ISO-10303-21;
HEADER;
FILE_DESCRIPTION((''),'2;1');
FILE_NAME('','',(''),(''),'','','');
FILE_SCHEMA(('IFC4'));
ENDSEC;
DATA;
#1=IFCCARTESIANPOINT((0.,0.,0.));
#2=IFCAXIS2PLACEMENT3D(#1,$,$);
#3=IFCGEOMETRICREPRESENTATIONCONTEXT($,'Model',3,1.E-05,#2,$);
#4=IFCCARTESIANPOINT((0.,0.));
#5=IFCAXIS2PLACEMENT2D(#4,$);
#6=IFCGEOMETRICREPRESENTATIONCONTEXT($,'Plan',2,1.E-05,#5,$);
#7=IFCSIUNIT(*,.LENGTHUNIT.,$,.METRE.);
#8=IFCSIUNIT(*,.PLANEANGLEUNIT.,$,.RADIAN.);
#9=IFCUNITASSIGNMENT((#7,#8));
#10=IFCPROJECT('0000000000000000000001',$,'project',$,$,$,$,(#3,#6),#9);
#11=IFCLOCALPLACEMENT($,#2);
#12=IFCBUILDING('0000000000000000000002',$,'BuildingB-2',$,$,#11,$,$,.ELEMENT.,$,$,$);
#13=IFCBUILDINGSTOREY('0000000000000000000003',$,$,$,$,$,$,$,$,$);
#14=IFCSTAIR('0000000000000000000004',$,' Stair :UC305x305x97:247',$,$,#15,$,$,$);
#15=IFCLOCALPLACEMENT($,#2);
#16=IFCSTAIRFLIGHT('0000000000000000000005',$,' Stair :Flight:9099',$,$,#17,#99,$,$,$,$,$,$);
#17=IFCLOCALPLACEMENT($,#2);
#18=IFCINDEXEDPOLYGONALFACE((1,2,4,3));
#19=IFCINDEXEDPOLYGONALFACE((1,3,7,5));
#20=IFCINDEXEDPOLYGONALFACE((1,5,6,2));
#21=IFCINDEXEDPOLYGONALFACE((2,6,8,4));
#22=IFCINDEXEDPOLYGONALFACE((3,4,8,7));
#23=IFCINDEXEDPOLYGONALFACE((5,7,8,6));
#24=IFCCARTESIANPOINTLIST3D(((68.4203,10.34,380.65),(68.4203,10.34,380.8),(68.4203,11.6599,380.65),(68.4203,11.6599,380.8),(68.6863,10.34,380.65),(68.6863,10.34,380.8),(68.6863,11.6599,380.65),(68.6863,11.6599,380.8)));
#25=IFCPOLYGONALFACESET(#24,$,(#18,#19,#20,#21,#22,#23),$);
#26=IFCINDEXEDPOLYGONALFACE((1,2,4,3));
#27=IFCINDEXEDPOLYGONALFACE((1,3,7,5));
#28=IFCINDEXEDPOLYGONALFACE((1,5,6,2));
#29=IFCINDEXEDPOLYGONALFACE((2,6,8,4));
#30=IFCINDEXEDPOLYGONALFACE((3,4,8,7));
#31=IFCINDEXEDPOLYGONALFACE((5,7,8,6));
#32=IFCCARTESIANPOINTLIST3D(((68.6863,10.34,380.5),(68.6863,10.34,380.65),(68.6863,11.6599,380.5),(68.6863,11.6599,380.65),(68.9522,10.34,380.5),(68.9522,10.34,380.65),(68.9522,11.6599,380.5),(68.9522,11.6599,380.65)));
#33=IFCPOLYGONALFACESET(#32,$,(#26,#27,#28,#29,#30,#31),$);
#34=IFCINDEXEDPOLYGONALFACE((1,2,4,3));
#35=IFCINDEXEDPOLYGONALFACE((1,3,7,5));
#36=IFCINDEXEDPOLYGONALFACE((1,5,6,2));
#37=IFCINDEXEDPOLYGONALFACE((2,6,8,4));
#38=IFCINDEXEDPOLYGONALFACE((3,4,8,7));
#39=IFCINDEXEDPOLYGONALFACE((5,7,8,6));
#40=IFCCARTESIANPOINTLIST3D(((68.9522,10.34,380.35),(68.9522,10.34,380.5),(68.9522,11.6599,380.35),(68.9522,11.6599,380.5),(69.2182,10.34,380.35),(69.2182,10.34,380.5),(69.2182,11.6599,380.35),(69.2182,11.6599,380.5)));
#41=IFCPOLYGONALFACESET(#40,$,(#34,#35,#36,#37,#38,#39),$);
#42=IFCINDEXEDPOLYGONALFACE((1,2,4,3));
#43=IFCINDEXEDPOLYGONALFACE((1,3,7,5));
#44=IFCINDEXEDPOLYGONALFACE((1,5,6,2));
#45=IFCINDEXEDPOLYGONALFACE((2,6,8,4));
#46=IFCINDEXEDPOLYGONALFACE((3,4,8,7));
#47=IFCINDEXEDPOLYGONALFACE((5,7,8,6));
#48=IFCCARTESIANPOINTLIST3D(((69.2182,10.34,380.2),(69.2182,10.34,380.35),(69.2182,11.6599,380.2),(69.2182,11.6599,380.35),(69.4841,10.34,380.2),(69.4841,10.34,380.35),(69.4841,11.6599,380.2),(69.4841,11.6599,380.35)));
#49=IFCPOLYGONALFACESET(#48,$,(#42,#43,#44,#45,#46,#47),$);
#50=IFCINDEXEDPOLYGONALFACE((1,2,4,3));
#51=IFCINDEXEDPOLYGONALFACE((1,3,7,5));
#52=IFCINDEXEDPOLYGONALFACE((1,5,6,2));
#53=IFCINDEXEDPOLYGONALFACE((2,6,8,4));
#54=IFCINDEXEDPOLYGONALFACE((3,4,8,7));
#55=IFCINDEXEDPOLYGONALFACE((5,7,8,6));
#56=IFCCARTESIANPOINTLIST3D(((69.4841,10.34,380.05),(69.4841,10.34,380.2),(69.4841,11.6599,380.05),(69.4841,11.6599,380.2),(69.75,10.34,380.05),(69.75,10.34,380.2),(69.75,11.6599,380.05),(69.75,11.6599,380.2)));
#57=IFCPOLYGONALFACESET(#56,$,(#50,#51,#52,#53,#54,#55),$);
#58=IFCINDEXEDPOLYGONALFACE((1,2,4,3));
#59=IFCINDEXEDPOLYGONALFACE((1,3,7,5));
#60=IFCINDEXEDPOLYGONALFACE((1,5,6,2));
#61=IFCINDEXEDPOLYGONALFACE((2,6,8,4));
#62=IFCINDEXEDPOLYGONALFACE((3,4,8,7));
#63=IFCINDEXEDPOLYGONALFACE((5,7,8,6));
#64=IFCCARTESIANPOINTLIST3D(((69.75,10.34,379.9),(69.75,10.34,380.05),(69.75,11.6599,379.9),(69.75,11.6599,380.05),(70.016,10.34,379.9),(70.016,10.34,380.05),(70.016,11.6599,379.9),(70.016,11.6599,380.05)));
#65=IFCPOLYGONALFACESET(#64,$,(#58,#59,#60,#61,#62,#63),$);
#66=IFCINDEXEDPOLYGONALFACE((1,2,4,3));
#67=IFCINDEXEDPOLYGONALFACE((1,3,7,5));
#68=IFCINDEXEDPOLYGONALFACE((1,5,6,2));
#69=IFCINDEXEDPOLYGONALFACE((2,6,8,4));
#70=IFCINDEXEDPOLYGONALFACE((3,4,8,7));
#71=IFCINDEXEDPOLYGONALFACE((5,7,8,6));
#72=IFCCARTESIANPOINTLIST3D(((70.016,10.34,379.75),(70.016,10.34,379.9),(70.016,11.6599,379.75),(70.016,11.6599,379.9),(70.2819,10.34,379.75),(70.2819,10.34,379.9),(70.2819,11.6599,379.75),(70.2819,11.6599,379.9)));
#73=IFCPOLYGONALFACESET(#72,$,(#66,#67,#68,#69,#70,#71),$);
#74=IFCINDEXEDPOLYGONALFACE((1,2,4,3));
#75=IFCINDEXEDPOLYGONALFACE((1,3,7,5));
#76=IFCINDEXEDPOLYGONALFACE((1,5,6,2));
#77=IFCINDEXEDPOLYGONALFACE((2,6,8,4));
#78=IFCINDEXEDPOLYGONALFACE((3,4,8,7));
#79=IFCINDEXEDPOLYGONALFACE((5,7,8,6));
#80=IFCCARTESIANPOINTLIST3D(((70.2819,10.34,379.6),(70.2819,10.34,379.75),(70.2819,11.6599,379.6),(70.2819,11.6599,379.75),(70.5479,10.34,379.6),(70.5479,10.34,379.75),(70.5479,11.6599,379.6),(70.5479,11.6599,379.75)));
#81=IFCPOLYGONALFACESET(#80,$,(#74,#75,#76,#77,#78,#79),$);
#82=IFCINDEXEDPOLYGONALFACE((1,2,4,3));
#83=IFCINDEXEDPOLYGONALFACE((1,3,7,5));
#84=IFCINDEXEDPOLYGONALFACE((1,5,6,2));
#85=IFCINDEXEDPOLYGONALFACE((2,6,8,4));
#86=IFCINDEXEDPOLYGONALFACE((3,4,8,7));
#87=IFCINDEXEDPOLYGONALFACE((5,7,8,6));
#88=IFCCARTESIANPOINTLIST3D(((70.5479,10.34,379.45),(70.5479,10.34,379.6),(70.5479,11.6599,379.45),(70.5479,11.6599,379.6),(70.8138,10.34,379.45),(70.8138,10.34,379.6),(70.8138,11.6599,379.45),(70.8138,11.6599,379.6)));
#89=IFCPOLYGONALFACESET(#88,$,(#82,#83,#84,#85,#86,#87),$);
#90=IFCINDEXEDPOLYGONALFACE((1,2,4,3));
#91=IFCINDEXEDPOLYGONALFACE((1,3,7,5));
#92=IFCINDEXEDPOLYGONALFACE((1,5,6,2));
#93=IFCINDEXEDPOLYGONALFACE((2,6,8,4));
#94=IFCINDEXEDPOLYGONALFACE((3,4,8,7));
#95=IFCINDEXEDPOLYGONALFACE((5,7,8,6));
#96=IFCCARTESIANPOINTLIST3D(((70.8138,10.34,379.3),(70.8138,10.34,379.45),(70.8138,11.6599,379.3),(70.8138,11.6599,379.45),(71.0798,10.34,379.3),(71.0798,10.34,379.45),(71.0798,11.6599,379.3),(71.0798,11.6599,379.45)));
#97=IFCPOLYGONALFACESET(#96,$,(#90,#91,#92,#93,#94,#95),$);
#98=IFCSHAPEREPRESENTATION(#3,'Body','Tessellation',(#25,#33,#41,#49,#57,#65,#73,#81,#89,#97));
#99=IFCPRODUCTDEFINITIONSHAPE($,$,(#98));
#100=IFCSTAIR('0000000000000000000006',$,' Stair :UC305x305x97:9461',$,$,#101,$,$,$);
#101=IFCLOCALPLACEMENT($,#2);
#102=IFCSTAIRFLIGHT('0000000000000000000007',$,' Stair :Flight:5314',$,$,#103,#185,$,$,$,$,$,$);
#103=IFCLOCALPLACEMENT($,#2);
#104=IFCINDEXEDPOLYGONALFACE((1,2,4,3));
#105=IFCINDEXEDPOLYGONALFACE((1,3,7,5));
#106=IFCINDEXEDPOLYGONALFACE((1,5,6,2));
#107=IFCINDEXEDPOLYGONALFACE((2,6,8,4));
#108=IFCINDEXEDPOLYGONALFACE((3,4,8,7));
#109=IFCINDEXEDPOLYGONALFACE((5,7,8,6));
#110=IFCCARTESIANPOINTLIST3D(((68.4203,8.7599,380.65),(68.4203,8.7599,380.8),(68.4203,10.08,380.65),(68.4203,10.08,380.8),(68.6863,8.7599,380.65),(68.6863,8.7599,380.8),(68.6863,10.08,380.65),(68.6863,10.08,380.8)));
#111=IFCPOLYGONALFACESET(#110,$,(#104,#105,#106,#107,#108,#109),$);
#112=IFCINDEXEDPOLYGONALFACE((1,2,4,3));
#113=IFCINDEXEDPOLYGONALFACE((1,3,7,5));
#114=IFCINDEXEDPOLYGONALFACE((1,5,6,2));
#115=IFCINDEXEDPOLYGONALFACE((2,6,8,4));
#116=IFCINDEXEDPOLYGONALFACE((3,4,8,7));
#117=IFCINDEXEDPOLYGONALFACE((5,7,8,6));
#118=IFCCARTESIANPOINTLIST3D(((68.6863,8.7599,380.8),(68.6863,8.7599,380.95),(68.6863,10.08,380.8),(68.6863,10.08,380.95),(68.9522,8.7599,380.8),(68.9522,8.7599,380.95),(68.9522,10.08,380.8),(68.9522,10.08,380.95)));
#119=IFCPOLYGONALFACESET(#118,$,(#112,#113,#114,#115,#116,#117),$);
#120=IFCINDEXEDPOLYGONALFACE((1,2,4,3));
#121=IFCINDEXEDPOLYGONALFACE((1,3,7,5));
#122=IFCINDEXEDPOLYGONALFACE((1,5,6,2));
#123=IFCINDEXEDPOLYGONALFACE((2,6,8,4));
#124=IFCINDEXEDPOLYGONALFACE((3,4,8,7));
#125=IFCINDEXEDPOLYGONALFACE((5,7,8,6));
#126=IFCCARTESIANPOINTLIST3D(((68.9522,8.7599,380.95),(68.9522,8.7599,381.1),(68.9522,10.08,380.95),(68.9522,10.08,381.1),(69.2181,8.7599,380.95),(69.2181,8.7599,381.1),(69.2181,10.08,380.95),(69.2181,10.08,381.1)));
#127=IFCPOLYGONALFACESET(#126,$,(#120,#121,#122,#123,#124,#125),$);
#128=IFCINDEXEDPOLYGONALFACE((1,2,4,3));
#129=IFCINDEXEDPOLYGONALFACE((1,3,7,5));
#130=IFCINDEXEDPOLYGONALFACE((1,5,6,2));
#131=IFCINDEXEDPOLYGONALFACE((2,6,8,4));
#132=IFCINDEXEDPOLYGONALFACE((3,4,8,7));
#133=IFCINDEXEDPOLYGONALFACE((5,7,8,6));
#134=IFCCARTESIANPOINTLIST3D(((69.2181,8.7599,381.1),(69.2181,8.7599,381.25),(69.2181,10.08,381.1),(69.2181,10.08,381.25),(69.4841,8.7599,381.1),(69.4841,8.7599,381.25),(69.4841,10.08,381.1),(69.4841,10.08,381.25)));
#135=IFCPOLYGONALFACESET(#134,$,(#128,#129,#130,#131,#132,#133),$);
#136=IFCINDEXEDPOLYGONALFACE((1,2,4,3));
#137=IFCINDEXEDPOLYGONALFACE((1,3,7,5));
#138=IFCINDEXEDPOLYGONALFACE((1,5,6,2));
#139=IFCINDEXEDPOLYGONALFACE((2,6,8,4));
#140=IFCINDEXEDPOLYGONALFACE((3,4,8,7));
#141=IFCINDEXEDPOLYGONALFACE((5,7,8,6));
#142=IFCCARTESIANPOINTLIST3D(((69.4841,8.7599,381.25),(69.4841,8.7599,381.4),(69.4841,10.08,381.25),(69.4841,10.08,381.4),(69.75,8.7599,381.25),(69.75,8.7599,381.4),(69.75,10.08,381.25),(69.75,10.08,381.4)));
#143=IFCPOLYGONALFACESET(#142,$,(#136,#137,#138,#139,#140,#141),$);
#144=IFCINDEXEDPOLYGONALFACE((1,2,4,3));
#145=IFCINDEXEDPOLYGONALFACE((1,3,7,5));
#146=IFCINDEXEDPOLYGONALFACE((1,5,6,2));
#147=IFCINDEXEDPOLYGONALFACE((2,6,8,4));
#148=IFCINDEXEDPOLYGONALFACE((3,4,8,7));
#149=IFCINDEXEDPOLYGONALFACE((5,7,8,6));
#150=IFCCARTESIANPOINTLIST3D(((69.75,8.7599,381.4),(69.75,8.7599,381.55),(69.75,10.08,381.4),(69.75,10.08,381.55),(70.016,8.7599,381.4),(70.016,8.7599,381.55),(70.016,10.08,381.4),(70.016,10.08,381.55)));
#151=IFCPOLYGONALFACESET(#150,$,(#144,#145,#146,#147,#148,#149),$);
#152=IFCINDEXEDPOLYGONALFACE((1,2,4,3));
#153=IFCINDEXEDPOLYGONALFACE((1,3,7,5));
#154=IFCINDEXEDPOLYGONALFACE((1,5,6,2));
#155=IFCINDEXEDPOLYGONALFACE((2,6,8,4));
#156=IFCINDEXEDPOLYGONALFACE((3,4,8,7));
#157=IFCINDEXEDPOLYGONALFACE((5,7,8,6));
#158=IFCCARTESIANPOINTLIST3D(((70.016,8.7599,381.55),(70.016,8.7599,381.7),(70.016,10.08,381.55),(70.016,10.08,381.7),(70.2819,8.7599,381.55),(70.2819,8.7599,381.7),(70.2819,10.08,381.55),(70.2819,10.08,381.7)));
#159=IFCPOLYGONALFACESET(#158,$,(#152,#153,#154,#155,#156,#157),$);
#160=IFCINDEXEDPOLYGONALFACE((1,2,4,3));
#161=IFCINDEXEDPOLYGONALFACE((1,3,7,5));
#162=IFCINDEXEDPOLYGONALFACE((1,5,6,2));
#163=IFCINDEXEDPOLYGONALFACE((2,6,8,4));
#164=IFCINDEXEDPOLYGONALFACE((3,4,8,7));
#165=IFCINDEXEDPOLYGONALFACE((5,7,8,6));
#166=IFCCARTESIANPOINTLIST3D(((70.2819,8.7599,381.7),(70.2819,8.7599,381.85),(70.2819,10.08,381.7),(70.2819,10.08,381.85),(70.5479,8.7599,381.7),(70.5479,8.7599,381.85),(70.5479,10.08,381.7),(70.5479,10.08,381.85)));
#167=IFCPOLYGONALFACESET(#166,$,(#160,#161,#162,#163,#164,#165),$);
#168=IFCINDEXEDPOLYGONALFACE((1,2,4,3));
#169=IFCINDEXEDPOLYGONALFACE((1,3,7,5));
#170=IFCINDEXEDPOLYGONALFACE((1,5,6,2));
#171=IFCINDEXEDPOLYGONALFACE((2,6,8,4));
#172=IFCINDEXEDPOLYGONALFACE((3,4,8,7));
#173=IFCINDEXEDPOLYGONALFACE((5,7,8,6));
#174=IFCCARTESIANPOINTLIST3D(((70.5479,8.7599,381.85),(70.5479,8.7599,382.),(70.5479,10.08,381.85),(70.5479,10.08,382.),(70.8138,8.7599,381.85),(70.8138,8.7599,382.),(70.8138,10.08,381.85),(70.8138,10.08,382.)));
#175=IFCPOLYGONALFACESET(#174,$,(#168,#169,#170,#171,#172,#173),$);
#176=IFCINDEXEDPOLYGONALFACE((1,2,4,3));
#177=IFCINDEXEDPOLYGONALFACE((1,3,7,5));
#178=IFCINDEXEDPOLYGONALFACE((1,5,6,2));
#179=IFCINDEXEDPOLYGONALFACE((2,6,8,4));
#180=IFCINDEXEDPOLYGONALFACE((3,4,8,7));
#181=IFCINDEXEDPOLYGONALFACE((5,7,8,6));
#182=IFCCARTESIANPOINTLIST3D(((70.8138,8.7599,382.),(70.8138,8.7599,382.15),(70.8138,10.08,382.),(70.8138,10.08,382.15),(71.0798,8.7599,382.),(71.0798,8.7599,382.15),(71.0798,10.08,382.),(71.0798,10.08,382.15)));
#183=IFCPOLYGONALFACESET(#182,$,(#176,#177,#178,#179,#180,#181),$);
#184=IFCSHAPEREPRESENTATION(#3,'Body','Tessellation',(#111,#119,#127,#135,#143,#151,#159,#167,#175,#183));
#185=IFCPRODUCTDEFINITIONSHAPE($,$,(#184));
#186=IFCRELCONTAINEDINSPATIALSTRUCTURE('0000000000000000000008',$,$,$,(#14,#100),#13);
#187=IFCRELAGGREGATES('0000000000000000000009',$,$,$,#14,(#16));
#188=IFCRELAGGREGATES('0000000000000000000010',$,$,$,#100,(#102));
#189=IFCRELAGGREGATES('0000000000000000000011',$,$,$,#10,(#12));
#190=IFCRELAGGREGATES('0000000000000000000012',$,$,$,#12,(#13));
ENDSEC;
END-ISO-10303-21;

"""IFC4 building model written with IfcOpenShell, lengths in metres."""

from ifc_helpers import new_model, si_unit, frame, origin, origin_2d, place, context, project, spatial, polyline, outline, extrude, element, aggregate, save


model = new_model("IFC4")

# Units and contexts
model_context = context("Model", 3, precision=1e-05, world=origin())
plan_context = context("Plan", 2, precision=1e-05, world=origin_2d())
ifc_project = project(units=[si_unit("LENGTHUNIT", "METRE"), si_unit("PLANEANGLEUNIT", "RADIAN")], contexts=[model_context, plan_context])

# Building, storey
building_placement = place(None, origin())
building = spatial("IfcBuilding", under=ifc_project, at=building_placement, Name="BuildingB-2", CompositionType="ELEMENT")
storey = spatial("IfcBuildingStorey", under=building)

# Stairs, stair flights
stair_1 = element("IfcStair", 1, inside=storey, Name=" Stair :UC305x305x97:247")
stair_flight_1 = element("IfcStairFlight", 2, Name=" Stair :Flight:9099", context=model_context, shape_type="SweptSolid", body=[
    extrude(outline(polyline([(68.6863, 11.6599, 380.8), (68.6863, 10.34, 380.8), (68.4203, 10.34, 380.8), (68.4203, 11.6599, 380.8), (68.6863, 11.6599, 380.8)])), origin(), (0.0, 0.0, -1.0), 0.15),
    extrude(outline(polyline([(68.9522, 11.6599, 380.8), (68.9522, 10.34, 380.8), (68.6863, 10.34, 380.8), (68.6863, 11.6599, 380.8), (68.9522, 11.6599, 380.8)])), frame((0.0, 0.0, -0.15)), (0.0, 0.0, -1.0), 0.15),
    extrude(outline(polyline([(69.2182, 11.6599, 380.8), (69.2182, 10.34, 380.8), (68.9522, 10.34, 380.8), (68.9522, 11.6599, 380.8), (69.2182, 11.6599, 380.8)])), frame((0.0, 0.0, -0.3)), (0.0, 0.0, -1.0), 0.15),
    extrude(outline(polyline([(69.4841, 11.6599, 380.8), (69.4841, 10.34, 380.8), (69.2182, 10.34, 380.8), (69.2182, 11.6599, 380.8), (69.4841, 11.6599, 380.8)])), frame((0.0, 0.0, -0.45)), (0.0, 0.0, -1.0), 0.15),
    extrude(outline(polyline([(69.75, 11.6599, 380.8), (69.75, 10.34, 380.8), (69.4841, 10.34, 380.8), (69.4841, 11.6599, 380.8), (69.75, 11.6599, 380.8)])), frame((0.0, 0.0, -0.6)), (0.0, 0.0, -1.0), 0.15),
    extrude(outline(polyline([(70.016, 11.6599, 380.8), (70.016, 10.34, 380.8), (69.75, 10.34, 380.8), (69.75, 11.6599, 380.8), (70.016, 11.6599, 380.8)])), frame((0.0, 0.0, -0.75)), (0.0, 0.0, -1.0), 0.15),
    extrude(outline(polyline([(70.2819, 11.6599, 380.8), (70.2819, 10.34, 380.8), (70.016, 10.34, 380.8), (70.016, 11.6599, 380.8), (70.2819, 11.6599, 380.8)])), frame((0.0, 0.0, -0.9)), (0.0, 0.0, -1.0), 0.15),
    extrude(outline(polyline([(70.5479, 11.6599, 380.8), (70.5479, 10.34, 380.8), (70.2819, 10.34, 380.8), (70.2819, 11.6599, 380.8), (70.5479, 11.6599, 380.8)])), frame((0.0, 0.0, -1.05)), (0.0, 0.0, -1.0), 0.15),
    extrude(outline(polyline([(70.8138, 11.6599, 380.8), (70.8138, 10.34, 380.8), (70.5479, 10.34, 380.8), (70.5479, 11.6599, 380.8), (70.8138, 11.6599, 380.8)])), frame((0.0, 0.0, -1.2)), (0.0, 0.0, -1.0), 0.15),
    extrude(outline(polyline([(71.0798, 11.6599, 380.8), (71.0798, 10.34, 380.8), (70.8138, 10.34, 380.8), (70.8138, 11.6599, 380.8), (71.0798, 11.6599, 380.8)])), frame((0.0, 0.0, -1.35)), (0.0, 0.0, -1.0), 0.15),
])
aggregate(stair_1, [stair_flight_1])
stair_2 = element("IfcStair", 3, inside=storey, Name=" Stair :UC305x305x97:9461")
stair_flight_2 = element("IfcStairFlight", 4, Name=" Stair :Flight:5314", context=model_context, shape_type="SweptSolid", body=[
    extrude(outline(polyline([(68.6863, 8.7599, 380.8), (68.6863, 10.08, 380.8), (68.4203, 10.08, 380.8), (68.4203, 8.7599, 380.8), (68.6863, 8.7599, 380.8)])), origin(), (0.0, 0.0, -1.0), 0.15),
    extrude(outline(polyline([(68.9522, 8.7599, 380.8), (68.9522, 10.08, 380.8), (68.6863, 10.08, 380.8), (68.6863, 8.7599, 380.8), (68.9522, 8.7599, 380.8)])), frame((0.0, 0.0, 0.15)), (0.0, 0.0, -1.0), 0.15),
    extrude(outline(polyline([(69.2181, 8.7599, 380.8), (69.2181, 10.08, 380.8), (68.9522, 10.08, 380.8), (68.9522, 8.7599, 380.8), (69.2181, 8.7599, 380.8)])), frame((0.0, 0.0, 0.3)), (0.0, 0.0, -1.0), 0.15),
    extrude(outline(polyline([(69.4841, 8.7599, 380.8), (69.4841, 10.08, 380.8), (69.2181, 10.08, 380.8), (69.2181, 8.7599, 380.8), (69.4841, 8.7599, 380.8)])), frame((0.0, 0.0, 0.45)), (0.0, 0.0, -1.0), 0.15),
    extrude(outline(polyline([(69.75, 8.7599, 380.8), (69.75, 10.08, 380.8), (69.4841, 10.08, 380.8), (69.4841, 8.7599, 380.8), (69.75, 8.7599, 380.8)])), frame((0.0, 0.0, 0.6)), (0.0, 0.0, -1.0), 0.15),
    extrude(outline(polyline([(70.016, 8.7599, 380.8), (70.016, 10.08, 380.8), (69.75, 10.08, 380.8), (69.75, 8.7599, 380.8), (70.016, 8.7599, 380.8)])), frame((0.0, 0.0, 0.75)), (0.0, 0.0, -1.0), 0.15),
    extrude(outline(polyline([(70.2819, 8.7599, 380.8), (70.2819, 10.08, 380.8), (70.016, 10.08, 380.8), (70.016, 8.7599, 380.8), (70.2819, 8.7599, 380.8)])), frame((0.0, 0.0, 0.9)), (0.0, 0.0, -1.0), 0.15),
    extrude(outline(polyline([(70.5479, 8.7599, 380.8), (70.5479, 10.08, 380.8), (70.2819, 10.08, 380.8), (70.2819, 8.7599, 380.8), (70.5479, 8.7599, 380.8)])), frame((0.0, 0.0, 1.05)), (0.0, 0.0, -1.0), 0.15),
    extrude(outline(polyline([(70.8138, 8.7599, 380.8), (70.8138, 10.08, 380.8), (70.5479, 10.08, 380.8), (70.5479, 8.7599, 380.8), (70.8138, 8.7599, 380.8)])), frame((0.0, 0.0, 1.2)), (0.0, 0.0, -1.0), 0.15),
    extrude(outline(polyline([(71.0798, 8.7599, 380.8), (71.0798, 10.08, 380.8), (70.8138, 10.08, 380.8), (70.8138, 8.7599, 380.8), (71.0798, 8.7599, 380.8)])), frame((0.0, 0.0, 1.35)), (0.0, 0.0, -1.0), 0.15),
])
aggregate(stair_2, [stair_flight_2])

save(model, "model.ifc")
